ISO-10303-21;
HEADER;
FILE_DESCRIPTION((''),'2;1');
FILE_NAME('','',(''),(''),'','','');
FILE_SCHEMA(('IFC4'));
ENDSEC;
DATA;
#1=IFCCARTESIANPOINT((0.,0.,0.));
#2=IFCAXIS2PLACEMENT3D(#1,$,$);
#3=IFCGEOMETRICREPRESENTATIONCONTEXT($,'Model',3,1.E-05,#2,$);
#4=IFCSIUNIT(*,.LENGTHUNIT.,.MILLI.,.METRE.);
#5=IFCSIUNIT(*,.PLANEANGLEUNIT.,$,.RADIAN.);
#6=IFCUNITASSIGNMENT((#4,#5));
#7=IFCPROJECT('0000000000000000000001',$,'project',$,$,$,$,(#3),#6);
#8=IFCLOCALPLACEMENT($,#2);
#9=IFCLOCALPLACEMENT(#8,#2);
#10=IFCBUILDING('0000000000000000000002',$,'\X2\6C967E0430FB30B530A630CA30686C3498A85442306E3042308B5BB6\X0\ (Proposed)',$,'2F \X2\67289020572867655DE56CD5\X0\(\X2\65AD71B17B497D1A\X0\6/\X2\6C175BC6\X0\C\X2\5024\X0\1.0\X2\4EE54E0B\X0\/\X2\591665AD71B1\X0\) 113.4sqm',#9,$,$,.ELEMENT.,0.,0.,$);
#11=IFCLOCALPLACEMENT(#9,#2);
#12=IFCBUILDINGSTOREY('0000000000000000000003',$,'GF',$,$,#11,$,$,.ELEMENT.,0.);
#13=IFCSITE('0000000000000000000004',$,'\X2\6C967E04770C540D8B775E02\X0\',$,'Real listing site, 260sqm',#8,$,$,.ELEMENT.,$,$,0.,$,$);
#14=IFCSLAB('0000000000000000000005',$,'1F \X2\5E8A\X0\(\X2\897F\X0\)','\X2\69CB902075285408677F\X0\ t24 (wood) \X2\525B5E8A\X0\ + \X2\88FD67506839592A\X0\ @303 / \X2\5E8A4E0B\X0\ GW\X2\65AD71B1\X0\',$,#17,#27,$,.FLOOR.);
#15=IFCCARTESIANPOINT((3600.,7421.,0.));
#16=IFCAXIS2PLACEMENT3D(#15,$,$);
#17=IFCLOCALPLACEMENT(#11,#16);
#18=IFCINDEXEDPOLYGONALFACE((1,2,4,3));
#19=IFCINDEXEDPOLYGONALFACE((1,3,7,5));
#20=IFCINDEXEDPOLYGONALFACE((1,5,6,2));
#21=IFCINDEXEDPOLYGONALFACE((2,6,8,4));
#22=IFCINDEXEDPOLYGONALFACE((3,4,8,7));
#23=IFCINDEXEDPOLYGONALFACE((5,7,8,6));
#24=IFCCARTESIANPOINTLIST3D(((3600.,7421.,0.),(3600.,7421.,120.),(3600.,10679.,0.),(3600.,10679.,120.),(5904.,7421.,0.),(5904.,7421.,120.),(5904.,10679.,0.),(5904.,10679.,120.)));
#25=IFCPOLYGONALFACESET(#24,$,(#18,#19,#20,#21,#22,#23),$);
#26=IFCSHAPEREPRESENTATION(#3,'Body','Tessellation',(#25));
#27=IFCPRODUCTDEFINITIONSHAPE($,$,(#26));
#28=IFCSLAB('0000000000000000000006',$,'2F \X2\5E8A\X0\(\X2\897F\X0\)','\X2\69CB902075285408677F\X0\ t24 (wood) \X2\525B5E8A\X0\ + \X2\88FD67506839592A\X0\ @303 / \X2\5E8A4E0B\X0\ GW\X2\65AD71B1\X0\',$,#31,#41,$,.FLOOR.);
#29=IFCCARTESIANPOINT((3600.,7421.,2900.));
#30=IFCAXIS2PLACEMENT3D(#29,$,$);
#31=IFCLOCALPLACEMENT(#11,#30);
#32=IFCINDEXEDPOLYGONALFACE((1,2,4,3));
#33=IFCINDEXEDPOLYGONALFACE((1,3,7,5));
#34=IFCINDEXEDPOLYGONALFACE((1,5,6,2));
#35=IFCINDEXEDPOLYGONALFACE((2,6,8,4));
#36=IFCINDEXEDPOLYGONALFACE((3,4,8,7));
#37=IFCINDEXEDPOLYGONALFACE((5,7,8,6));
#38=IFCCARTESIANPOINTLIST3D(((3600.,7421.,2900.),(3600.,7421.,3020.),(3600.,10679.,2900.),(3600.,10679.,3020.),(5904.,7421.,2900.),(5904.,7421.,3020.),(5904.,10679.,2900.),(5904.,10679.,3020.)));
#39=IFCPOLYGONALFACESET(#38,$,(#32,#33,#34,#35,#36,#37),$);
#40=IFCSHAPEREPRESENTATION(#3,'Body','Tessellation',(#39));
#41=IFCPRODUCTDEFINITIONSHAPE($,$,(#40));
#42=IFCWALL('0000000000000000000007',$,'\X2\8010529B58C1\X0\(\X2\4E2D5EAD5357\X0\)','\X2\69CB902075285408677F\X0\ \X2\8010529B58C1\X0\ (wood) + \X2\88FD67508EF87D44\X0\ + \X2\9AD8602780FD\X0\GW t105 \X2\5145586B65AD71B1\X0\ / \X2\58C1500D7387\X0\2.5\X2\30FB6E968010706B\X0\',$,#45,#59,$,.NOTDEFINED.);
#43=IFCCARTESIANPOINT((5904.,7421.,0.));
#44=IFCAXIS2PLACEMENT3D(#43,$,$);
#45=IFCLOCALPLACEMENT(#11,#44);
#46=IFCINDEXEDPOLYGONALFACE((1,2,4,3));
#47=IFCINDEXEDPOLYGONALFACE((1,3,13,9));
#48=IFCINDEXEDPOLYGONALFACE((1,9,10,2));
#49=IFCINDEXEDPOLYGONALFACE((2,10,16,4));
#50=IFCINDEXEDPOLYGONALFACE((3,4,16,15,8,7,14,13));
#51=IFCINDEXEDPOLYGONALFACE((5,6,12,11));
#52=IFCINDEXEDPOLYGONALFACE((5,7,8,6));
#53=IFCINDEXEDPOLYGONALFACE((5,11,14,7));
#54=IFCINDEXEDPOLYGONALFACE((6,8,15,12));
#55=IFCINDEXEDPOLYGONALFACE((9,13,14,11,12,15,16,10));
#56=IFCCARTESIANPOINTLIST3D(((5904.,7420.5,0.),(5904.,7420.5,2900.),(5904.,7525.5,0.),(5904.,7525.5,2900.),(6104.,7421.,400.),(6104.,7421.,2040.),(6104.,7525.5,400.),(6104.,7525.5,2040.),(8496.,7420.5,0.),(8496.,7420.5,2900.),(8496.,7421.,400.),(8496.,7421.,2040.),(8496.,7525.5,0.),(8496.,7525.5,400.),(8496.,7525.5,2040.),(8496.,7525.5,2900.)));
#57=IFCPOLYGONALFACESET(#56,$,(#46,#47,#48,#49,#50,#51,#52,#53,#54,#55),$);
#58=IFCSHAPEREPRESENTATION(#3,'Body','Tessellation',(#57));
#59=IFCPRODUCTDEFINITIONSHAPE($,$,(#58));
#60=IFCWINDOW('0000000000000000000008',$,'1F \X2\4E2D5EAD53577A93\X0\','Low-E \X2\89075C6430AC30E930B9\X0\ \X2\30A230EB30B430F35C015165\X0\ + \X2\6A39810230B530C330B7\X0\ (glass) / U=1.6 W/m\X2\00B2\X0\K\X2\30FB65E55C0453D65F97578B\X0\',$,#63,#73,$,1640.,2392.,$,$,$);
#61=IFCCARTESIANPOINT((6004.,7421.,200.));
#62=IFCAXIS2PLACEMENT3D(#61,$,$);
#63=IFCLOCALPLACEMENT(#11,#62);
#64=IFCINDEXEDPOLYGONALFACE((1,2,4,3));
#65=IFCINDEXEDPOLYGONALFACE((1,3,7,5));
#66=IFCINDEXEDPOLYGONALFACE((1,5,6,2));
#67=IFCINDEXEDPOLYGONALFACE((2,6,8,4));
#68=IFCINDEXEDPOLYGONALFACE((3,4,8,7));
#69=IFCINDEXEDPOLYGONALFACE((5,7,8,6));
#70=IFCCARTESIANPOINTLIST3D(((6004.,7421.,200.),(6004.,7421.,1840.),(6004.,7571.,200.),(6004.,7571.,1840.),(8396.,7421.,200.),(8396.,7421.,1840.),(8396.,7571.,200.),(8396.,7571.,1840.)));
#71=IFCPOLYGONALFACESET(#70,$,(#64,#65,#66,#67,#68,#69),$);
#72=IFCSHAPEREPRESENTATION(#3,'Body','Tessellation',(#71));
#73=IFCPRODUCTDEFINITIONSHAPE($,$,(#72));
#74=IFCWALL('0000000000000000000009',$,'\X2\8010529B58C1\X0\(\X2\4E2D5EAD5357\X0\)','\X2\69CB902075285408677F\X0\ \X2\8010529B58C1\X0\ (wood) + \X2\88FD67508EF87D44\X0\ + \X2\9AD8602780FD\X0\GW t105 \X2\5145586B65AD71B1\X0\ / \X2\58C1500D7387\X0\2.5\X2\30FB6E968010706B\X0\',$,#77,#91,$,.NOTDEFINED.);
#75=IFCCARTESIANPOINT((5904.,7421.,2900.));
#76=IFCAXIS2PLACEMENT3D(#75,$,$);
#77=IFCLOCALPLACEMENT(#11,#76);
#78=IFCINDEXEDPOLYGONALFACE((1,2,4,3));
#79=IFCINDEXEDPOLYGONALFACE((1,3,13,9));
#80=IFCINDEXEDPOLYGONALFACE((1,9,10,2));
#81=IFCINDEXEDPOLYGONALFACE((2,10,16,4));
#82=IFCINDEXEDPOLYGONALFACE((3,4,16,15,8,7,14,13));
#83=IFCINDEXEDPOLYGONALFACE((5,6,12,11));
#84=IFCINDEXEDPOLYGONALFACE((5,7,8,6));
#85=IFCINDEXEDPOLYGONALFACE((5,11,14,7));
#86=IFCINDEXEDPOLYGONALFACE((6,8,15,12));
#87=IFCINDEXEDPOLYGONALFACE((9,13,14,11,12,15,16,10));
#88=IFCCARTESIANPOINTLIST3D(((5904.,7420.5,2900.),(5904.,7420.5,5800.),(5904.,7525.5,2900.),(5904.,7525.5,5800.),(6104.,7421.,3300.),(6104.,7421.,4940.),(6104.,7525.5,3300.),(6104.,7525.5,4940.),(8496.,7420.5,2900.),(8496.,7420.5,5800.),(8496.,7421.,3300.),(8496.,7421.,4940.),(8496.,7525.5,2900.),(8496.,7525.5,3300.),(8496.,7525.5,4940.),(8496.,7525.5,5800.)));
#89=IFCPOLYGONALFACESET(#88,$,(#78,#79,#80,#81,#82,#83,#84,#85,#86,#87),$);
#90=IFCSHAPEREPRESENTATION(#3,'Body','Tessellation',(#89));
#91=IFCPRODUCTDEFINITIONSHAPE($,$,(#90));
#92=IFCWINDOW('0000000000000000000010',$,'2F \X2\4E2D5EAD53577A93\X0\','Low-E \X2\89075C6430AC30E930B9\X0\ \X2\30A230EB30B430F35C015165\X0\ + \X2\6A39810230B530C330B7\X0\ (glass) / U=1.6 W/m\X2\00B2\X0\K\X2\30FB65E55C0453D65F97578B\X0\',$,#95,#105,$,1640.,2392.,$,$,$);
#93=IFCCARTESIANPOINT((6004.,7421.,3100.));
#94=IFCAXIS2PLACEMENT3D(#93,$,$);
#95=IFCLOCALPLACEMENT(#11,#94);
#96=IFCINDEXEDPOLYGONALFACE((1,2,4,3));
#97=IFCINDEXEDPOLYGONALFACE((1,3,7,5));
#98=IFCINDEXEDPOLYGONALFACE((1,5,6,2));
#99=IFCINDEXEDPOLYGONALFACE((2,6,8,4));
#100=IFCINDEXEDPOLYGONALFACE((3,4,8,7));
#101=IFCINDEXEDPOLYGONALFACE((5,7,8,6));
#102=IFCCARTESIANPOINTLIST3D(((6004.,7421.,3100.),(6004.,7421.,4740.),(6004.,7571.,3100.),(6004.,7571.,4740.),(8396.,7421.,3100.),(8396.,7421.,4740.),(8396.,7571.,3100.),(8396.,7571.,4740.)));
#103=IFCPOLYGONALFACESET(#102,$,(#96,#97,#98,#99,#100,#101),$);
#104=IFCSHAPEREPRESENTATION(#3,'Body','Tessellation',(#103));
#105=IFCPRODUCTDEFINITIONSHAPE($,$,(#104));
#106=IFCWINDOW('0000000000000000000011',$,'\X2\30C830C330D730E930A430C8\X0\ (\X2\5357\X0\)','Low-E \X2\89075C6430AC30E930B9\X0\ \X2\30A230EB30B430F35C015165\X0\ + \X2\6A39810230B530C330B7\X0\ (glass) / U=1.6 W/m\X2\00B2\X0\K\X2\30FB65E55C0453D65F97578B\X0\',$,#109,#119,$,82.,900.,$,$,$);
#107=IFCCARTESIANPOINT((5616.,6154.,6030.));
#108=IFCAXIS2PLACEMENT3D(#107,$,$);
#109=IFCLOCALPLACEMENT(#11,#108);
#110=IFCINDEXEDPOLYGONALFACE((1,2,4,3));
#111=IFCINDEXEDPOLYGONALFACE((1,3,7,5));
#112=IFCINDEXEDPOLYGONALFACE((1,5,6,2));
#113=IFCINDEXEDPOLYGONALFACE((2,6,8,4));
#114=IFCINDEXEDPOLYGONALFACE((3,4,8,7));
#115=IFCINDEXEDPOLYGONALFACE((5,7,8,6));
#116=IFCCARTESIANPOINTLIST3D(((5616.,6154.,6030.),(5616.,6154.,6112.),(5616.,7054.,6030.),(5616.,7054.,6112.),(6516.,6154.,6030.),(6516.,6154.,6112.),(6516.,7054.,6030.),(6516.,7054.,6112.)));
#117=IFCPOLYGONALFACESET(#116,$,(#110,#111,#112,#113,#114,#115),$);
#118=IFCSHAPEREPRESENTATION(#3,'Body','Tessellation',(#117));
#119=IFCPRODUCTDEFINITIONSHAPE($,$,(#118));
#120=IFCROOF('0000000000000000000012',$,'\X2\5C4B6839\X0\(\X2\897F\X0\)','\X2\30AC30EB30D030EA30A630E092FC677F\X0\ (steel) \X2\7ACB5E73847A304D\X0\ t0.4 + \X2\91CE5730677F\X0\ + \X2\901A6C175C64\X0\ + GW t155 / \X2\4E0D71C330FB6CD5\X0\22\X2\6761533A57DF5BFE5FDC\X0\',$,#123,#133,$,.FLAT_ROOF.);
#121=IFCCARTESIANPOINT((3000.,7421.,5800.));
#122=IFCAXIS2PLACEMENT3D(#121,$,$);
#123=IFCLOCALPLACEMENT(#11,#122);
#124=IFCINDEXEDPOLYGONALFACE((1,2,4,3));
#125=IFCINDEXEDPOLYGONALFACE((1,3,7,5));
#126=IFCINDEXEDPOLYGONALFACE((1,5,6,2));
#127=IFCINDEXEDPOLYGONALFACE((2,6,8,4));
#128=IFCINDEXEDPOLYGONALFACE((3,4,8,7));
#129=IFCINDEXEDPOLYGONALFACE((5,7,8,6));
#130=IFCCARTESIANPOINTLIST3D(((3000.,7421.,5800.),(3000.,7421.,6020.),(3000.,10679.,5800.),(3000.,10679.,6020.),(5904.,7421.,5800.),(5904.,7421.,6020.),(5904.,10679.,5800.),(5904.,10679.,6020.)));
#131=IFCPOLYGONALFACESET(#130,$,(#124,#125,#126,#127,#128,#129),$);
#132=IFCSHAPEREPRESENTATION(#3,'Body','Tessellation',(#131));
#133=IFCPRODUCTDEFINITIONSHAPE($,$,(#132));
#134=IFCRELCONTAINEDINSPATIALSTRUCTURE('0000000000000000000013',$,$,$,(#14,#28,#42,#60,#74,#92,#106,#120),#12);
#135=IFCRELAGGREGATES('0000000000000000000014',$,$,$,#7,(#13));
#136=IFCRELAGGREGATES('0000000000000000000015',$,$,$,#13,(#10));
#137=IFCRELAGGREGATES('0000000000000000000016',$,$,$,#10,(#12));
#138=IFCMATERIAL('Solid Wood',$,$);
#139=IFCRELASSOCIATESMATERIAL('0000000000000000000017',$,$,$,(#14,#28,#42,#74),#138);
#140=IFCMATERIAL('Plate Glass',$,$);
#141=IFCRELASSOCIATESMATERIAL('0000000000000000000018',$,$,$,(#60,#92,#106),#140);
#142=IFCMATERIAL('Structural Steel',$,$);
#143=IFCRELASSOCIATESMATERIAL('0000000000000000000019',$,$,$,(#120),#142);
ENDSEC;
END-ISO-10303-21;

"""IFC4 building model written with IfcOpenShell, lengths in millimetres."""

from ifc_helpers import new_model, si_unit, frame, frame_2d, origin, place, context, project, spatial, rectangle, extrude, material, element, fill, save


model = new_model("IFC4")

# Units and contexts
model_context = context("Model", 3, precision=1e-05, world=origin())
ifc_project = project(units=[si_unit("LENGTHUNIT", "METRE", prefix="MILLI"), si_unit("PLANEANGLEUNIT", "RADIAN")], contexts=[model_context])

# Site, building, storey
site_placement = place(None, origin())
site = spatial("IfcSite", under=ifc_project, at=site_placement, Name="沖縄県名護市", ObjectType="Real listing site, 260sqm", CompositionType="ELEMENT", RefElevation=0.0)
building_placement = place(site_placement, origin())
building = spatial("IfcBuilding", under=site, at=building_placement, Name="沖縄・サウナと水風呂のある家 (Proposed)", ObjectType="2F 木造在来工法(断熱等級6/気密C値1.0以下/外断熱) 113.4sqm", CompositionType="ELEMENT", ElevationOfRefHeight=0.0, ElevationOfTerrain=0.0)
storey_placement = place(building_placement, origin())
storey = spatial("IfcBuildingStorey", under=building, at=storey_placement, Name="GF", CompositionType="ELEMENT", Elevation=0.0)

# Shared definitions
ifc_material_1 = material(Name="Solid Wood")

# Slabs
slab_1_placement = place(storey_placement, frame((3600.0, 7421.0, 0.0)))
element("IfcSlab", 1, at=slab_1_placement, inside=storey, material=ifc_material_1, Name="1F 床(西)", Description="構造用合板 t24 (wood) 剛床 + 製材根太 @303 / 床下 GW断熱", PredefinedType="FLOOR", context=model_context, shape_type="SweptSolid", body=[
    extrude(rectangle(XDim=2304.0, YDim=3258.0, at=frame_2d((1152.0, 1629.0))), frame((3600.0, 7421.0, 0.0)), (0.0, 0.0, 1.0), 120.0),
])
slab_2_placement = place(storey_placement, frame((3600.0, 7421.0, 2900.0)))
element("IfcSlab", 2, at=slab_2_placement, inside=storey, material=ifc_material_1, Name="2F 床(西)", Description="構造用合板 t24 (wood) 剛床 + 製材根太 @303 / 床下 GW断熱", PredefinedType="FLOOR", context=model_context, shape_type="SweptSolid", body=[
    extrude(rectangle(XDim=2304.0, YDim=3258.0, at=frame_2d((1152.0, 1629.0))), frame((3600.0, 7421.0, 2900.0)), (0.0, 0.0, 1.0), 120.0),
])

# Wall, opening, window
wall_1_placement = place(storey_placement, frame((5904.0, 7421.0, 0.0)))
wall_1 = element("IfcWall", 3, at=wall_1_placement, inside=storey, material=ifc_material_1, Name="耐力壁(中庭南)", Description="構造用合板 耐力壁 (wood) + 製材軸組 + 高性能GW t105 充填断熱 / 壁倍率2.5・準耐火", PredefinedType="NOTDEFINED", context=model_context, shape_type="SweptSolid", body=[
    extrude(rectangle(XDim=2592.0, YDim=105.0, at=frame_2d((1296.0, 52.0))), frame((5904.0, 7421.0, 0.0)), (0.0, 0.0, 1.0), 2900.0),
])
opening_1_placement = place(storey_placement, frame((6004.0, 7421.0, 200.0)))
opening_1 = element("IfcOpeningElement", 4, at=opening_1_placement, cuts=wall_1, PredefinedType="NOTDEFINED", context=model_context, shape_type="SweptSolid", body=[
    extrude(rectangle(XDim=2392.0, YDim=150.0, at=frame_2d((1196.0, 75.0))), frame((6004.0, 7421.0, 200.0)), (0.0, 0.0, 1.0), 1640.0),
])
ifc_material_2 = material(Name="Plate Glass")
window_1_placement = place(storey_placement, frame((6004.0, 7421.0, 200.0)))
window_1 = element("IfcWindow", 5, at=window_1_placement, inside=storey, material=ifc_material_2, Name="1F 中庭南窓", Description="Low-E 複層ガラス アルゴン封入 + 樹脂サッシ (glass) / U=1.6 W/m²K・日射取得型", OverallHeight=1640.0, OverallWidth=2392.0, context=model_context, shape_type="SweptSolid", body=[
    extrude(rectangle(XDim=2392.0, YDim=150.0, at=frame_2d((1196.0, 75.0))), frame((6004.0, 7421.0, 200.0)), (0.0, 0.0, 1.0), 1640.0),
])
fill(opening_1, window_1)

# Wall, opening, window
wall_2_placement = place(storey_placement, frame((5904.0, 7421.0, 2900.0)))
wall_2 = element("IfcWall", 6, at=wall_2_placement, inside=storey, material=ifc_material_1, Name="耐力壁(中庭南)", Description="構造用合板 耐力壁 (wood) + 製材軸組 + 高性能GW t105 充填断熱 / 壁倍率2.5・準耐火", PredefinedType="NOTDEFINED", context=model_context, shape_type="SweptSolid", body=[
    extrude(rectangle(XDim=2592.0, YDim=105.0, at=frame_2d((1296.0, 52.0))), frame((5904.0, 7421.0, 2900.0)), (0.0, 0.0, 1.0), 2900.0),
])
opening_2_placement = place(storey_placement, frame((6004.0, 7421.0, 3100.0)))
opening_2 = element("IfcOpeningElement", 7, at=opening_2_placement, cuts=wall_2, PredefinedType="NOTDEFINED", context=model_context, shape_type="SweptSolid", body=[
    extrude(rectangle(XDim=2392.0, YDim=150.0, at=frame_2d((1196.0, 75.0))), frame((6004.0, 7421.0, 3100.0)), (0.0, 0.0, 1.0), 1640.0),
])
window_2_placement = place(storey_placement, frame((6004.0, 7421.0, 3100.0)))
window_2 = element("IfcWindow", 8, at=window_2_placement, inside=storey, material=ifc_material_2, Name="2F 中庭南窓", Description="Low-E 複層ガラス アルゴン封入 + 樹脂サッシ (glass) / U=1.6 W/m²K・日射取得型", OverallHeight=1640.0, OverallWidth=2392.0, context=model_context, shape_type="SweptSolid", body=[
    extrude(rectangle(XDim=2392.0, YDim=150.0, at=frame_2d((1196.0, 75.0))), frame((6004.0, 7421.0, 3100.0)), (0.0, 0.0, 1.0), 1640.0),
])
fill(opening_2, window_2)

# Window
window_3_placement = place(storey_placement, frame((5616.0, 6154.0, 6030.0)))
element("IfcWindow", 9, at=window_3_placement, inside=storey, material=ifc_material_2, Name="トップライト (南)", Description="Low-E 複層ガラス アルゴン封入 + 樹脂サッシ (glass) / U=1.6 W/m²K・日射取得型", OverallHeight=82.0, OverallWidth=900.0, context=model_context, shape_type="SweptSolid", body=[
    extrude(rectangle(XDim=900.0, YDim=900.0, at=frame_2d((450.0, 450.0))), frame((5616.0, 6154.0, 6030.0)), (0.0, 0.0, 1.0), 82.0),
])

# Roof
ifc_material_3 = material(Name="Structural Steel")
for number, where, name in (
    (10, (3000.0, 7421.0, 5800.0), "屋根(西)"),
):
    element("IfcRoof", number, at=place(storey_placement, frame(where)), inside=storey, material=ifc_material_3, Name=name, Description="ガルバリウム鋼板 (steel) 立平葺き t0.4 + 野地板 + 通気層 + GW t155 / 不燃・法22条区域対応", PredefinedType="FLAT_ROOF", context=model_context, shape_type="SweptSolid", body=[
        extrude(rectangle(XDim=2904.0, YDim=3258.0, at=frame_2d((1452.0, 1629.0))), frame((3000.0, 7421.0, 5800.0)), (0.0, 0.0, 1.0), 220.0),
    ])

save(model, "model.ifc")
